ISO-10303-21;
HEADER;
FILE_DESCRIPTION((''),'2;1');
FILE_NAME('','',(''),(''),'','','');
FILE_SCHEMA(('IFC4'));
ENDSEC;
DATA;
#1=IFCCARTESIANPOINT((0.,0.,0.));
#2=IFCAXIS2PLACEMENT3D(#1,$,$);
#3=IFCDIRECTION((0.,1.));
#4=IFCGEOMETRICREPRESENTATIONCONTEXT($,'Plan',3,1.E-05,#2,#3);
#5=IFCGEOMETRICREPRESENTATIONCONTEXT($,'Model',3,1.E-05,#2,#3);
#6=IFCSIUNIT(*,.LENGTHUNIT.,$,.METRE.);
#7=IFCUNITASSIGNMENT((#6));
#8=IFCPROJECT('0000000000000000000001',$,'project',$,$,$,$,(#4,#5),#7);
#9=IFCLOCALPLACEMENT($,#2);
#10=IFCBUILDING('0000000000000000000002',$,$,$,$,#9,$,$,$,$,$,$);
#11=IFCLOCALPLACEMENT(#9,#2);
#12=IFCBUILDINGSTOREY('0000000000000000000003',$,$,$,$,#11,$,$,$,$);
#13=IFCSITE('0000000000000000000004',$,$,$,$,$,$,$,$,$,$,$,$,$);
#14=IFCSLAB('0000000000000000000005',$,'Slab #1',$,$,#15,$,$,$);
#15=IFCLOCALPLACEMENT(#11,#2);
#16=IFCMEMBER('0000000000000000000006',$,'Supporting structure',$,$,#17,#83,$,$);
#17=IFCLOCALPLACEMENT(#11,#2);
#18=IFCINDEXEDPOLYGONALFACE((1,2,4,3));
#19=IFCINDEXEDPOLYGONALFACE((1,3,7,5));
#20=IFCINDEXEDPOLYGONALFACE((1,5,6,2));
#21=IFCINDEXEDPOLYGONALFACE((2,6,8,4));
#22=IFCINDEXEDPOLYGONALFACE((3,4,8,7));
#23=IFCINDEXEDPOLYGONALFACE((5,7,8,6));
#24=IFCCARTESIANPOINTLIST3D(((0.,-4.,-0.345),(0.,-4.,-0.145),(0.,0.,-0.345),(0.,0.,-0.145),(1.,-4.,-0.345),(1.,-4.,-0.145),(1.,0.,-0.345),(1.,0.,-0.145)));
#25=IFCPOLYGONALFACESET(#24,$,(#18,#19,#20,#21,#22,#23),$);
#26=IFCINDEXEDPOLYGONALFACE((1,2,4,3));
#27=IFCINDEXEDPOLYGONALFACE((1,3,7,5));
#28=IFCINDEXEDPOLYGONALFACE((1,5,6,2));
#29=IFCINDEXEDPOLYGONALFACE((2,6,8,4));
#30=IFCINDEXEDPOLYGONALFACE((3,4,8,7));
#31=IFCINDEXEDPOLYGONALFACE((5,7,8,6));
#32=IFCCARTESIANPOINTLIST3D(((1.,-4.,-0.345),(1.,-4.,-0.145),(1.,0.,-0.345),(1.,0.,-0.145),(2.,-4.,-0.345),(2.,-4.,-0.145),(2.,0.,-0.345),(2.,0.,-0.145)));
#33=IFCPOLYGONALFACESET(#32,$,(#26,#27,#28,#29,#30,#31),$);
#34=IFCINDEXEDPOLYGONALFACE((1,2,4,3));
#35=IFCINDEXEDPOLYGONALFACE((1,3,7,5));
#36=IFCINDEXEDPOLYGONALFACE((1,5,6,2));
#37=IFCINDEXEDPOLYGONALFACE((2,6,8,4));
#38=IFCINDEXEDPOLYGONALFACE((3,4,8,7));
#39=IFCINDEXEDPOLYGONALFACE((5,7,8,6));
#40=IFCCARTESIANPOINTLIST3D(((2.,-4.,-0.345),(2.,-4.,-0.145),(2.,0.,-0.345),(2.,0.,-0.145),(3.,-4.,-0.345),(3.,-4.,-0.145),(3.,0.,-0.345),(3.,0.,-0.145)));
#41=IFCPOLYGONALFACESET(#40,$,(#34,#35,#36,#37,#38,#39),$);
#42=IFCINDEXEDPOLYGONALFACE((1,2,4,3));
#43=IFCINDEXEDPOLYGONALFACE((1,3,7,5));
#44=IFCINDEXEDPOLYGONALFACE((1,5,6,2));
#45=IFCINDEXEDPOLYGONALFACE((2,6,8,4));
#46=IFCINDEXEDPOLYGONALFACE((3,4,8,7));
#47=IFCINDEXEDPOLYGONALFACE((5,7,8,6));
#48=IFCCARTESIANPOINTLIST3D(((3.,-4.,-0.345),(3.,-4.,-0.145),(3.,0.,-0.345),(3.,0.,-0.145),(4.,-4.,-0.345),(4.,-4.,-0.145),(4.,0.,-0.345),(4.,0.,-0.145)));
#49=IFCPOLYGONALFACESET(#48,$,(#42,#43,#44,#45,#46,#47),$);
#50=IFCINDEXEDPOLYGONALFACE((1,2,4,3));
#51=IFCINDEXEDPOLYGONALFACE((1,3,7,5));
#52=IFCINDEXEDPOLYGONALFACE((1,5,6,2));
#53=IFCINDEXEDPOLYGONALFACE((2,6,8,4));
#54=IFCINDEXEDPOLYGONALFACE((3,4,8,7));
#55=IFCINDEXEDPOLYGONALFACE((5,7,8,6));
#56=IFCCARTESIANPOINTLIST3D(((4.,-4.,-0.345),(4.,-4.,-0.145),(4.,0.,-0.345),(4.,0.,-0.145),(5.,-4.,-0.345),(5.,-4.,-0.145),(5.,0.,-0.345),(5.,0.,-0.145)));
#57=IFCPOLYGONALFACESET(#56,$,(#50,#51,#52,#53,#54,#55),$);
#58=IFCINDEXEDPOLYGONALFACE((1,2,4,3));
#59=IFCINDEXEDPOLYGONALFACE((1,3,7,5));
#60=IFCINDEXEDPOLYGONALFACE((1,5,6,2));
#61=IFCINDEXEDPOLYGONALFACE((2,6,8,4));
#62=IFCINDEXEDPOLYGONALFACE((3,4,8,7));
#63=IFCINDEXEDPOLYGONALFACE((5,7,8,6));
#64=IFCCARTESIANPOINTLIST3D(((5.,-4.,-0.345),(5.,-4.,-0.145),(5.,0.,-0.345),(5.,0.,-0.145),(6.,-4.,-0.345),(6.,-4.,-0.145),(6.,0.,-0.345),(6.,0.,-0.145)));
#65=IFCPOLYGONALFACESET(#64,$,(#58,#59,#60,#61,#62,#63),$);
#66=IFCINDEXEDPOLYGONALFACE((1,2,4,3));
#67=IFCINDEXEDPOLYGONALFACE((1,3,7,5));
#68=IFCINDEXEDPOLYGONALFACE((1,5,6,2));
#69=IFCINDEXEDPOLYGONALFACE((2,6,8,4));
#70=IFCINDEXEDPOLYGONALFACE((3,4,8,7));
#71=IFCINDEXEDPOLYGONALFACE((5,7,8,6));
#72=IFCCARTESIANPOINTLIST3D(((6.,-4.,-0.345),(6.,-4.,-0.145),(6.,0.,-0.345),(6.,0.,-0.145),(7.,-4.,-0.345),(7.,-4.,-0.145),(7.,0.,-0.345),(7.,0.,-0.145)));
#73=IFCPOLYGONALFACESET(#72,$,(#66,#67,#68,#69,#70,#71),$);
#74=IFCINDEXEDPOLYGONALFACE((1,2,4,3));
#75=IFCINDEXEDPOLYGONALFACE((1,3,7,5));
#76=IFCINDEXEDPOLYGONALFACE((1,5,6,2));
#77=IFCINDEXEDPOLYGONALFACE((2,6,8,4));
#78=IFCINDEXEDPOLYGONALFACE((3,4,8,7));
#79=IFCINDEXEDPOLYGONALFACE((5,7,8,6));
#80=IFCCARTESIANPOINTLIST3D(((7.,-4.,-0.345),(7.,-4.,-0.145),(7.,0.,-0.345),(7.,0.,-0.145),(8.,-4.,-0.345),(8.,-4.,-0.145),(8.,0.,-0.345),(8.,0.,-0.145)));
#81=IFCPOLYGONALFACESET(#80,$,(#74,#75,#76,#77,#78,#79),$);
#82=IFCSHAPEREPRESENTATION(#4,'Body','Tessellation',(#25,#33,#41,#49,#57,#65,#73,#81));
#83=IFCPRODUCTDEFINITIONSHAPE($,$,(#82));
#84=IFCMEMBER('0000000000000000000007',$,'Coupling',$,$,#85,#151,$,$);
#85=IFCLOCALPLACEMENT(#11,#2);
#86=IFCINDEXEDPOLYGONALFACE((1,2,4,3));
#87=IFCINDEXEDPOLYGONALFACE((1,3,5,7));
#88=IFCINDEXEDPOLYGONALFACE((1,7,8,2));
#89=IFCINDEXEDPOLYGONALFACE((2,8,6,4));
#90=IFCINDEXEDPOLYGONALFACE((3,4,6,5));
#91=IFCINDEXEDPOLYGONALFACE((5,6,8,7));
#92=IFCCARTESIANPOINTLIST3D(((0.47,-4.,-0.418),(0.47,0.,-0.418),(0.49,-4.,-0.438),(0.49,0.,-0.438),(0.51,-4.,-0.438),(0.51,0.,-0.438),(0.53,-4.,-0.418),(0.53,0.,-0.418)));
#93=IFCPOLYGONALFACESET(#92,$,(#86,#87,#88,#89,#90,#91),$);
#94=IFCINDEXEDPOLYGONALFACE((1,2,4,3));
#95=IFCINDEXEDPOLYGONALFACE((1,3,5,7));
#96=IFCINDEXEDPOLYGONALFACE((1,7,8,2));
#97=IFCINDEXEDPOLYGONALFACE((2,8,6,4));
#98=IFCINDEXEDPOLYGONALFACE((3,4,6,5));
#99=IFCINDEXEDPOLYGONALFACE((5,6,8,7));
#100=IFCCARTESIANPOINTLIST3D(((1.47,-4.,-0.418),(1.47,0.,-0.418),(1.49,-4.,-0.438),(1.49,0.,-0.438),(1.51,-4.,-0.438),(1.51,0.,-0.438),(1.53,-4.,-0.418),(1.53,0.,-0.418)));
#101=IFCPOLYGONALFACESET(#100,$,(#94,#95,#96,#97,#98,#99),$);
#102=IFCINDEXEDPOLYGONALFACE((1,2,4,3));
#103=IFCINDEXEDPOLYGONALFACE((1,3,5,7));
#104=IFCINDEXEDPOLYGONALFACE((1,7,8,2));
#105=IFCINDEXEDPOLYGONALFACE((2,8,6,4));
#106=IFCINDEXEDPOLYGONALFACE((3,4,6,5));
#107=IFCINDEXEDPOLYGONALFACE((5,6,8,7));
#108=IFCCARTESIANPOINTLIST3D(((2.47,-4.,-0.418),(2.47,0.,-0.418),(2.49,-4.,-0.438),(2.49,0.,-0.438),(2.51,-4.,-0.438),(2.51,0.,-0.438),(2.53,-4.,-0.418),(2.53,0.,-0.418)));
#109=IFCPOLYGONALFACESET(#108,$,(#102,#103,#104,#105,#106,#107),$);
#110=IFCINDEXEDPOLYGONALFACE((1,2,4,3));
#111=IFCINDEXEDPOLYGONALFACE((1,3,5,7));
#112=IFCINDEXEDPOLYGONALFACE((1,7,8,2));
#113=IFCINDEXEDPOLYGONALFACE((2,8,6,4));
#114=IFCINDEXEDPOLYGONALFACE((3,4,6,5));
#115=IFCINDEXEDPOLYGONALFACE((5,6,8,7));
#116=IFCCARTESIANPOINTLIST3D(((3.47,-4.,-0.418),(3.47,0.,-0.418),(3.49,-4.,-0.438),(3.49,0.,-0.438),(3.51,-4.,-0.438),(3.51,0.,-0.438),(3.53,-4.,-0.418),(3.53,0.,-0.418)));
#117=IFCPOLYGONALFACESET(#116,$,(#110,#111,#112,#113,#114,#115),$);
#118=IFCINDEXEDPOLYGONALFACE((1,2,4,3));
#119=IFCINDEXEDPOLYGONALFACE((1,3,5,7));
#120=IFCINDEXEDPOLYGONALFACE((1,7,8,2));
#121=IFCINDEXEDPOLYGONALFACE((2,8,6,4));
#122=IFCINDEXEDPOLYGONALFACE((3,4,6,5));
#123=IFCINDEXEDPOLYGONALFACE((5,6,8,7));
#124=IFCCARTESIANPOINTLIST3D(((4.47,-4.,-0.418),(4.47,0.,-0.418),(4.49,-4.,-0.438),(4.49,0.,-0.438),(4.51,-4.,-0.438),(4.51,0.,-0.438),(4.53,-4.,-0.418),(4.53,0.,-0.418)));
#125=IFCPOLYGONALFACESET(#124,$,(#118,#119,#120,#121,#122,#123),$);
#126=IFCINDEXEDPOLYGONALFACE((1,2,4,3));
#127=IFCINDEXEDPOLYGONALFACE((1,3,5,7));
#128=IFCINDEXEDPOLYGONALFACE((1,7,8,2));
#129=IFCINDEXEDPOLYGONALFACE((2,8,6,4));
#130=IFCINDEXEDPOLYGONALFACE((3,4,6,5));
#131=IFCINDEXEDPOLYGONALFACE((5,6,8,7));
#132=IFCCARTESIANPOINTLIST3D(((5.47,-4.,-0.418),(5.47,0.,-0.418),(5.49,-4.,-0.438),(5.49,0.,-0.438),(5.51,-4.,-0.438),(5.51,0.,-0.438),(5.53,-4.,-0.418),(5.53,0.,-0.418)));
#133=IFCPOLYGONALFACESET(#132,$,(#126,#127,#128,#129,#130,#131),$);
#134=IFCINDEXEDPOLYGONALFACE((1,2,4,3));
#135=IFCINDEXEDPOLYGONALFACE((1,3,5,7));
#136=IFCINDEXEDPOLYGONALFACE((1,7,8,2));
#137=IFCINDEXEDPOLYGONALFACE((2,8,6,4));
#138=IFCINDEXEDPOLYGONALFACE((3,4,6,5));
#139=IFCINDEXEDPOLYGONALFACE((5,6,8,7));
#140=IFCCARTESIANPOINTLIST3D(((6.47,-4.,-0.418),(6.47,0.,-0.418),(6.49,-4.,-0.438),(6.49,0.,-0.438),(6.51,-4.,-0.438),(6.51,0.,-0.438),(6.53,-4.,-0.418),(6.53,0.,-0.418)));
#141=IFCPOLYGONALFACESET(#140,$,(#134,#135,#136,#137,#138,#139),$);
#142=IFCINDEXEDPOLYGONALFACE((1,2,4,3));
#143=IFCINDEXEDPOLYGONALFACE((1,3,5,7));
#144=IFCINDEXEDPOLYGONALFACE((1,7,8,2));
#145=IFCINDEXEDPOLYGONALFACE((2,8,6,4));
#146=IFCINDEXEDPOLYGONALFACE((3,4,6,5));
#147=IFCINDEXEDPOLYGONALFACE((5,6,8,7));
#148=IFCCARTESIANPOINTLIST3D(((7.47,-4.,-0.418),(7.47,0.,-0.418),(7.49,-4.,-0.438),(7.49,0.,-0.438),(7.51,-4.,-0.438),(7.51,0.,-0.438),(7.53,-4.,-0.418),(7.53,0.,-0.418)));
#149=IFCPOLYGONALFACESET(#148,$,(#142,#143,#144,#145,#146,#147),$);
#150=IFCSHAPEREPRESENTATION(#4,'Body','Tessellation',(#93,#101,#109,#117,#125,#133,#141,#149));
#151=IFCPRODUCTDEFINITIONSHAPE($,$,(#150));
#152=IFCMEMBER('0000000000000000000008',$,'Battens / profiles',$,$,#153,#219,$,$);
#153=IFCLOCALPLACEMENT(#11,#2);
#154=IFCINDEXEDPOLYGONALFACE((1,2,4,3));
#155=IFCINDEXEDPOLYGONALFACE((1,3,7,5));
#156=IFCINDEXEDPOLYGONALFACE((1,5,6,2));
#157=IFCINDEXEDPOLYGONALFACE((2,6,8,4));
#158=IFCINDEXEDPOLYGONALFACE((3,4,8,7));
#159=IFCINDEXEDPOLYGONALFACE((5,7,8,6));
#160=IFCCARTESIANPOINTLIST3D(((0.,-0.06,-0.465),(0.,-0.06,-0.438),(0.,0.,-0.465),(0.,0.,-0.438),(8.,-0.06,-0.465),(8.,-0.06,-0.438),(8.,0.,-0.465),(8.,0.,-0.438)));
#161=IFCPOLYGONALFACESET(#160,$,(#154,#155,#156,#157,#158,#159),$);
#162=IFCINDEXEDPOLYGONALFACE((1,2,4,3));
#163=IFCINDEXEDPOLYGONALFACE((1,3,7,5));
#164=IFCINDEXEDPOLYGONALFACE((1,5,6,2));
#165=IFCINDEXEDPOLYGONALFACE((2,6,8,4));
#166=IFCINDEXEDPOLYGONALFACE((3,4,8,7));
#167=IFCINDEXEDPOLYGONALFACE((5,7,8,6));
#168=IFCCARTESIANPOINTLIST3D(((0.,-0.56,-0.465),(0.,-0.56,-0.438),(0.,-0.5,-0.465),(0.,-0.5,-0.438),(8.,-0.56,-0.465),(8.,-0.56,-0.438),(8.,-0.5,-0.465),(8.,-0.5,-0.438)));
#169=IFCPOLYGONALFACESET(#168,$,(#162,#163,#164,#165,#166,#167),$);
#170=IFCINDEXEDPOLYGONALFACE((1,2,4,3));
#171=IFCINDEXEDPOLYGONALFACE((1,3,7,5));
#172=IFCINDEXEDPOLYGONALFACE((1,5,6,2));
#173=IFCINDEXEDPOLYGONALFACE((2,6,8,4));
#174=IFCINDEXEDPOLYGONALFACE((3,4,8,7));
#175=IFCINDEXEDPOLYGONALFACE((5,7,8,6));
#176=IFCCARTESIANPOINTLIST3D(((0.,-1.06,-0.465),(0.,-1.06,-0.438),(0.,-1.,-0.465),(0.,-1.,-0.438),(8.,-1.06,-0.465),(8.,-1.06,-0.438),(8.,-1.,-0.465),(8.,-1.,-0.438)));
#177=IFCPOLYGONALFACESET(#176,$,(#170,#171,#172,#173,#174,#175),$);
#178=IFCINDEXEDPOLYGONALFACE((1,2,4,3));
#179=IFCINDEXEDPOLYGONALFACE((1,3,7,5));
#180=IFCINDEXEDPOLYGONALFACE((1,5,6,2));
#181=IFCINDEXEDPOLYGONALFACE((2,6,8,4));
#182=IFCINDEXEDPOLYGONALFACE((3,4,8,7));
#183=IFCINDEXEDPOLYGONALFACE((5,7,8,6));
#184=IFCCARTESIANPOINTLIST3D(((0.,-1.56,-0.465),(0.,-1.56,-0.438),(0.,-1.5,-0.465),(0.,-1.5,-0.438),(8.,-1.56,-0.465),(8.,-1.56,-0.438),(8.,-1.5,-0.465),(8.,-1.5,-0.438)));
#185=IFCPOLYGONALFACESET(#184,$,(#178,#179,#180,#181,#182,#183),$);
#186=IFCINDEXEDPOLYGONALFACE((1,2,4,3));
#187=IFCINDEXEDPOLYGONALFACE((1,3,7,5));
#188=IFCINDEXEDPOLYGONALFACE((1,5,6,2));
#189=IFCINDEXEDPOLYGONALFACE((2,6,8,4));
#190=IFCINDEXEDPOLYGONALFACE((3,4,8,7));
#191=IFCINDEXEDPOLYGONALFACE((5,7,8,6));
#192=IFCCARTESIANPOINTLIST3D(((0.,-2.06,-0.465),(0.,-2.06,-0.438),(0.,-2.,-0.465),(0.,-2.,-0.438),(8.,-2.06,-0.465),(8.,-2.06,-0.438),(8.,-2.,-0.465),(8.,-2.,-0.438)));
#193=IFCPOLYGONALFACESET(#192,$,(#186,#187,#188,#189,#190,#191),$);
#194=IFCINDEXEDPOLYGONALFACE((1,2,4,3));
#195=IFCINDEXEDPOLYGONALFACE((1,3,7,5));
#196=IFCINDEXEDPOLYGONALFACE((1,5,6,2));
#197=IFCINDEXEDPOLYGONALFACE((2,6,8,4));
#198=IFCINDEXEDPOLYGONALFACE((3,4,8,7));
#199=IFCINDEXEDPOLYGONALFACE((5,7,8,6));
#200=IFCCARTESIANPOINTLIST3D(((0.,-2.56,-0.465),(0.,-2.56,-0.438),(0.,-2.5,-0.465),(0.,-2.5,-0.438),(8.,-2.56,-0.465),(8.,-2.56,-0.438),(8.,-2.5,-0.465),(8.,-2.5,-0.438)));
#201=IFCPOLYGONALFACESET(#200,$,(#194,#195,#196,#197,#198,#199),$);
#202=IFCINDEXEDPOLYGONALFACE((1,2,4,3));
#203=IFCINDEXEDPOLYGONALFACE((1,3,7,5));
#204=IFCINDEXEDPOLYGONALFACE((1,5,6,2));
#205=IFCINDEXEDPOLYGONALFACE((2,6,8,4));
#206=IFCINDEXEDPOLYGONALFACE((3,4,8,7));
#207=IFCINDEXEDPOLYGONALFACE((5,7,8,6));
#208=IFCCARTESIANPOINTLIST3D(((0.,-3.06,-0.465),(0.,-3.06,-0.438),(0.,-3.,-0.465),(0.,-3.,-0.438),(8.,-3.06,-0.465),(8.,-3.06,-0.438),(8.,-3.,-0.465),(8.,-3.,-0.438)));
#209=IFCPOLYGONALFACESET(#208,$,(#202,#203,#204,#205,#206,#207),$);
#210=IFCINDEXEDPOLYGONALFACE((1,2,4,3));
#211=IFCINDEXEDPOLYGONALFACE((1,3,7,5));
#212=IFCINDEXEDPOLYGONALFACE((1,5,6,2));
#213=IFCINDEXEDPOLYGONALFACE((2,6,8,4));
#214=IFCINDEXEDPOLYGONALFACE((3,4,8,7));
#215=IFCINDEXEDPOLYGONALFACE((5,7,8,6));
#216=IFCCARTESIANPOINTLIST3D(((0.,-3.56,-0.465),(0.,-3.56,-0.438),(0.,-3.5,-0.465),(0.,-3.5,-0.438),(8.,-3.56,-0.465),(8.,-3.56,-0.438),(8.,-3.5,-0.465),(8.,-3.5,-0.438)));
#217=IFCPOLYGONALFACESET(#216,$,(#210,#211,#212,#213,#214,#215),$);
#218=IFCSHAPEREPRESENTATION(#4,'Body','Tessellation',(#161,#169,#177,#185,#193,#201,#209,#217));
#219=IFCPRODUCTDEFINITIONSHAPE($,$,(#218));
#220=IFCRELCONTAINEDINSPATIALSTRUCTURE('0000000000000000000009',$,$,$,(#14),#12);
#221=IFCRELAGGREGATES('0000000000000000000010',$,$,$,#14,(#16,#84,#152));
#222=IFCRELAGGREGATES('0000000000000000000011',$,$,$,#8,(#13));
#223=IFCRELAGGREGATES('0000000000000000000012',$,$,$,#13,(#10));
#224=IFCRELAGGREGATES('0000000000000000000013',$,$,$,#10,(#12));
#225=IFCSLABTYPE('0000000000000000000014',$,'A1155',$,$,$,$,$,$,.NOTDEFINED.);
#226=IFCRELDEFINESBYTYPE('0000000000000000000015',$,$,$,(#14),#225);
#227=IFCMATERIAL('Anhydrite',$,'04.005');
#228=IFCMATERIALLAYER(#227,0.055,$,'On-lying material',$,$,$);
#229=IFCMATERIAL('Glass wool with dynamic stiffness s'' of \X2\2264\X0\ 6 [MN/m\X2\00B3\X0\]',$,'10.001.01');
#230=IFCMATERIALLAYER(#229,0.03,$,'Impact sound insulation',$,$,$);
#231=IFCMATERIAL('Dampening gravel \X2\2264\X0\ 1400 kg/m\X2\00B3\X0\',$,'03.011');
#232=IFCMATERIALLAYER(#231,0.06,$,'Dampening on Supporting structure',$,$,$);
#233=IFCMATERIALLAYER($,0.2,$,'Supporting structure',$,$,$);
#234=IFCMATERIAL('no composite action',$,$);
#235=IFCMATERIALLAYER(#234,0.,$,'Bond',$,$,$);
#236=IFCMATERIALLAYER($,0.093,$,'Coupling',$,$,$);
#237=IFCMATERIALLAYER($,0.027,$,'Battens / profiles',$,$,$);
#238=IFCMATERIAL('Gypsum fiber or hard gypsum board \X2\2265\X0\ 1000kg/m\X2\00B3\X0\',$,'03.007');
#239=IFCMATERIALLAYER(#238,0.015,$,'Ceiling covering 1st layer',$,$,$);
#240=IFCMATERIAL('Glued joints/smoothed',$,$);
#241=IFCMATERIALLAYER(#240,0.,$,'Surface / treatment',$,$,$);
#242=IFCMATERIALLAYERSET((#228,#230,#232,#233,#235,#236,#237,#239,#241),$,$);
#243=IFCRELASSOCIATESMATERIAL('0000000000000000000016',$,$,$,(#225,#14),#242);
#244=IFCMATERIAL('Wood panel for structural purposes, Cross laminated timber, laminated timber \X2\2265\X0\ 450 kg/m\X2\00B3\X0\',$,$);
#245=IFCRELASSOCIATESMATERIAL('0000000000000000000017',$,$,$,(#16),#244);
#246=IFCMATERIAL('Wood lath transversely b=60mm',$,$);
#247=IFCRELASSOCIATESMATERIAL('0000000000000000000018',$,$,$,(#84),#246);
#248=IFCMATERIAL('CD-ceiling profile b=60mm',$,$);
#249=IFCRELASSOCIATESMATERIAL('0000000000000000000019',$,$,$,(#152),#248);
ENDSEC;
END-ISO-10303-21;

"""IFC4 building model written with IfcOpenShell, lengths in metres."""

from ifc_helpers import new_model, si_unit, direction, frame, frame_2d, origin, place, context, project, spatial, polyline, rectangle, outline, extrude, material, layer, layer_set, type_object, element, aggregate, save


model = new_model("IFC4")

# Units and contexts
plan_context = context("Plan", 3, precision=1e-05, world=origin(), true_north=direction((0.0, 1.0)))
model_context = context("Model", 3, precision=1e-05, world=origin(), true_north=direction((0.0, 1.0)))
ifc_project = project(units=[si_unit("LENGTHUNIT", "METRE")], contexts=[plan_context, model_context])

# Site, building, storey
site = spatial("IfcSite", under=ifc_project)
building_placement = place(None, origin())
building = spatial("IfcBuilding", under=site, at=building_placement)
storey_placement = place(building_placement, origin())
storey = spatial("IfcBuildingStorey", under=building, at=storey_placement)

# Slab, members
ifc_material_1 = material(Name="Anhydrite", Category="04.005")
ifc_layer_1 = layer(ifc_material_1, 0.055, Name="On-lying material")
ifc_material_2 = material(Name="Glass wool with dynamic stiffness s' of ≤ 6 [MN/m³]", Category="10.001.01")
ifc_layer_2 = layer(ifc_material_2, 0.03, Name="Impact sound insulation")
ifc_material_3 = material(Name="Dampening gravel ≤ 1400 kg/m³", Category="03.011")
ifc_layer_3 = layer(ifc_material_3, 0.06, Name="Dampening on Supporting structure")
ifc_layer_4 = layer(None, 0.2, Name="Supporting structure")
ifc_material_4 = material(Name="no composite action")
ifc_layer_5 = layer(ifc_material_4, 0.0, Name="Bond")
ifc_layer_6 = layer(None, 0.093, Name="Coupling")
ifc_layer_7 = layer(None, 0.027, Name="Battens / profiles")
ifc_material_5 = material(Name="Gypsum fiber or hard gypsum board ≥ 1000kg/m³", Category="03.007")
ifc_layer_8 = layer(ifc_material_5, 0.015, Name="Ceiling covering 1st layer")
ifc_material_6 = material(Name="Glued joints/smoothed")
ifc_layer_9 = layer(ifc_material_6, 0.0, Name="Surface / treatment")
ifc_layer_set = layer_set([ifc_layer_1, ifc_layer_2, ifc_layer_3, ifc_layer_4, ifc_layer_5, ifc_layer_6, ifc_layer_7, ifc_layer_8, ifc_layer_9])
slab_type = type_object("IfcSlabType", Name="A1155", PredefinedType="NOTDEFINED", material=ifc_layer_set)
slab_placement = place(None, frame((0.0, 0.0, 0.0), z_axis=(0.0, 0.0, -1.0), x_axis=(1.0, 0.0, 0.0)))
slab = element("IfcSlab", 1, at=slab_placement, inside=storey, type_object=slab_type, material=ifc_layer_set, Name="Slab #1")
ifc_material_7 = material(Name="Wood panel for structural purposes, Cross laminated timber, laminated timber ≥ 450 kg/m³")
member_1_placement = place(slab_placement, origin())
member_1 = element("IfcMember", 2, at=member_1_placement, material=ifc_material_7, Name="Supporting structure", context=plan_context, shape_type="SweptSolid", body=[
    extrude(rectangle(XDim=1.0, YDim=0.2, at=frame_2d((0.5, 0.1), x_axis=(1.0, 0.0))), frame((0.0, 4.0, 0.145), z_axis=(0.0, -1.0, 0.0), x_axis=(1.0, 0.0, 0.0)), (0.0, 0.0, 1.0), 4.0),
    extrude(rectangle(XDim=1.0, YDim=0.2, at=frame_2d((0.5, 0.1), x_axis=(1.0, 0.0))), frame((1.0, 4.0, 0.145), z_axis=(0.0, -1.0, 0.0), x_axis=(1.0, 0.0, 0.0)), (0.0, 0.0, 1.0), 4.0),
    extrude(rectangle(XDim=1.0, YDim=0.2, at=frame_2d((0.5, 0.1), x_axis=(1.0, 0.0))), frame((2.0, 4.0, 0.145), z_axis=(0.0, -1.0, 0.0), x_axis=(1.0, 0.0, 0.0)), (0.0, 0.0, 1.0), 4.0),
    extrude(rectangle(XDim=1.0, YDim=0.2, at=frame_2d((0.5, 0.1), x_axis=(1.0, 0.0))), frame((3.0, 4.0, 0.145), z_axis=(0.0, -1.0, 0.0), x_axis=(1.0, 0.0, 0.0)), (0.0, 0.0, 1.0), 4.0),
    extrude(rectangle(XDim=1.0, YDim=0.2, at=frame_2d((0.5, 0.1), x_axis=(1.0, 0.0))), frame((4.0, 4.0, 0.145), z_axis=(0.0, -1.0, 0.0), x_axis=(1.0, 0.0, 0.0)), (0.0, 0.0, 1.0), 4.0),
    extrude(rectangle(XDim=1.0, YDim=0.2, at=frame_2d((0.5, 0.1), x_axis=(1.0, 0.0))), frame((5.0, 4.0, 0.145), z_axis=(0.0, -1.0, 0.0), x_axis=(1.0, 0.0, 0.0)), (0.0, 0.0, 1.0), 4.0),
    extrude(rectangle(XDim=1.0, YDim=0.2, at=frame_2d((0.5, 0.1), x_axis=(1.0, 0.0))), frame((6.0, 4.0, 0.145), z_axis=(0.0, -1.0, 0.0), x_axis=(1.0, 0.0, 0.0)), (0.0, 0.0, 1.0), 4.0),
    extrude(rectangle(XDim=1.0, YDim=0.2, at=frame_2d((0.5, 0.1), x_axis=(1.0, 0.0))), frame((7.0, 4.0, 0.145), z_axis=(0.0, -1.0, 0.0), x_axis=(1.0, 0.0, 0.0)), (0.0, 0.0, 1.0), 4.0),
])
ifc_material_8 = material(Name="Wood lath transversely b=60mm")
member_2_placement = place(slab_placement, origin())
member_2 = element("IfcMember", 3, at=member_2_placement, material=ifc_material_8, Name="Coupling", context=plan_context, shape_type="SweptSolid", body=[
    extrude(outline(polyline([(0.0, 0.0), (0.06, 0.0), (0.04, 0.02), (0.02, 0.02), (0.0, 0.0)])), frame((0.47, 4.0, 0.418), z_axis=(0.0, -1.0, 0.0), x_axis=(1.0, 0.0, 0.0)), (0.0, 0.0, 1.0), 4.0),
    extrude(outline(polyline([(0.0, 0.0), (0.06, 0.0), (0.04, 0.02), (0.02, 0.02), (0.0, 0.0)])), frame((1.47, 4.0, 0.418), z_axis=(0.0, -1.0, 0.0), x_axis=(1.0, 0.0, 0.0)), (0.0, 0.0, 1.0), 4.0),
    extrude(outline(polyline([(0.0, 0.0), (0.06, 0.0), (0.04, 0.02), (0.02, 0.02), (0.0, 0.0)])), frame((2.47, 4.0, 0.418), z_axis=(0.0, -1.0, 0.0), x_axis=(1.0, 0.0, 0.0)), (0.0, 0.0, 1.0), 4.0),
    extrude(outline(polyline([(0.0, 0.0), (0.06, 0.0), (0.04, 0.02), (0.02, 0.02), (0.0, 0.0)])), frame((3.47, 4.0, 0.418), z_axis=(0.0, -1.0, 0.0), x_axis=(1.0, 0.0, 0.0)), (0.0, 0.0, 1.0), 4.0),
    extrude(outline(polyline([(0.0, 0.0), (0.06, 0.0), (0.04, 0.02), (0.02, 0.02), (0.0, 0.0)])), frame((4.47, 4.0, 0.418), z_axis=(0.0, -1.0, 0.0), x_axis=(1.0, 0.0, 0.0)), (0.0, 0.0, 1.0), 4.0),
    extrude(outline(polyline([(0.0, 0.0), (0.06, 0.0), (0.04, 0.02), (0.02, 0.02), (0.0, 0.0)])), frame((5.47, 4.0, 0.418), z_axis=(0.0, -1.0, 0.0), x_axis=(1.0, 0.0, 0.0)), (0.0, 0.0, 1.0), 4.0),
    extrude(outline(polyline([(0.0, 0.0), (0.06, 0.0), (0.04, 0.02), (0.02, 0.02), (0.0, 0.0)])), frame((6.47, 4.0, 0.418), z_axis=(0.0, -1.0, 0.0), x_axis=(1.0, 0.0, 0.0)), (0.0, 0.0, 1.0), 4.0),
    extrude(outline(polyline([(0.0, 0.0), (0.06, 0.0), (0.04, 0.02), (0.02, 0.02), (0.0, 0.0)])), frame((7.47, 4.0, 0.418), z_axis=(0.0, -1.0, 0.0), x_axis=(1.0, 0.0, 0.0)), (0.0, 0.0, 1.0), 4.0),
])
ifc_material_9 = material(Name="CD-ceiling profile b=60mm")
member_3_placement = place(slab_placement, origin())
member_3 = element("IfcMember", 4, at=member_3_placement, material=ifc_material_9, Name="Battens / profiles", context=plan_context, shape_type="SweptSolid", body=[
    extrude(rectangle(XDim=0.06, YDim=0.027, at=frame_2d((0.03, 0.0135), x_axis=(1.0, 0.0))), frame((0.0, 0.0, 0.438), z_axis=(1.0, 0.0, 0.0), x_axis=(0.0, 1.0, 0.0)), (0.0, 0.0, 1.0), 8.0),
    extrude(rectangle(XDim=0.06, YDim=0.027, at=frame_2d((0.03, 0.0135), x_axis=(1.0, 0.0))), frame((0.0, 0.5, 0.438), z_axis=(1.0, 0.0, 0.0), x_axis=(0.0, 1.0, 0.0)), (0.0, 0.0, 1.0), 8.0),
    extrude(rectangle(XDim=0.06, YDim=0.027, at=frame_2d((0.03, 0.0135), x_axis=(1.0, 0.0))), frame((0.0, 1.0, 0.438), z_axis=(1.0, 0.0, 0.0), x_axis=(0.0, 1.0, 0.0)), (0.0, 0.0, 1.0), 8.0),
    extrude(rectangle(XDim=0.06, YDim=0.027, at=frame_2d((0.03, 0.0135), x_axis=(1.0, 0.0))), frame((0.0, 1.5, 0.438), z_axis=(1.0, 0.0, 0.0), x_axis=(0.0, 1.0, 0.0)), (0.0, 0.0, 1.0), 8.0),
    extrude(rectangle(XDim=0.06, YDim=0.027, at=frame_2d((0.03, 0.0135), x_axis=(1.0, 0.0))), frame((0.0, 2.0, 0.438), z_axis=(1.0, 0.0, 0.0), x_axis=(0.0, 1.0, 0.0)), (0.0, 0.0, 1.0), 8.0),
    extrude(rectangle(XDim=0.06, YDim=0.027, at=frame_2d((0.03, 0.0135), x_axis=(1.0, 0.0))), frame((0.0, 2.5, 0.438), z_axis=(1.0, 0.0, 0.0), x_axis=(0.0, 1.0, 0.0)), (0.0, 0.0, 1.0), 8.0),
    extrude(rectangle(XDim=0.06, YDim=0.027, at=frame_2d((0.03, 0.0135), x_axis=(1.0, 0.0))), frame((0.0, 3.0, 0.438), z_axis=(1.0, 0.0, 0.0), x_axis=(0.0, 1.0, 0.0)), (0.0, 0.0, 1.0), 8.0),
    extrude(rectangle(XDim=0.06, YDim=0.027, at=frame_2d((0.03, 0.0135), x_axis=(1.0, 0.0))), frame((0.0, 3.5, 0.438), z_axis=(1.0, 0.0, 0.0), x_axis=(0.0, 1.0, 0.0)), (0.0, 0.0, 1.0), 8.0),
])
aggregate(slab, [member_1, member_2, member_3])

save(model, "model.ifc")
